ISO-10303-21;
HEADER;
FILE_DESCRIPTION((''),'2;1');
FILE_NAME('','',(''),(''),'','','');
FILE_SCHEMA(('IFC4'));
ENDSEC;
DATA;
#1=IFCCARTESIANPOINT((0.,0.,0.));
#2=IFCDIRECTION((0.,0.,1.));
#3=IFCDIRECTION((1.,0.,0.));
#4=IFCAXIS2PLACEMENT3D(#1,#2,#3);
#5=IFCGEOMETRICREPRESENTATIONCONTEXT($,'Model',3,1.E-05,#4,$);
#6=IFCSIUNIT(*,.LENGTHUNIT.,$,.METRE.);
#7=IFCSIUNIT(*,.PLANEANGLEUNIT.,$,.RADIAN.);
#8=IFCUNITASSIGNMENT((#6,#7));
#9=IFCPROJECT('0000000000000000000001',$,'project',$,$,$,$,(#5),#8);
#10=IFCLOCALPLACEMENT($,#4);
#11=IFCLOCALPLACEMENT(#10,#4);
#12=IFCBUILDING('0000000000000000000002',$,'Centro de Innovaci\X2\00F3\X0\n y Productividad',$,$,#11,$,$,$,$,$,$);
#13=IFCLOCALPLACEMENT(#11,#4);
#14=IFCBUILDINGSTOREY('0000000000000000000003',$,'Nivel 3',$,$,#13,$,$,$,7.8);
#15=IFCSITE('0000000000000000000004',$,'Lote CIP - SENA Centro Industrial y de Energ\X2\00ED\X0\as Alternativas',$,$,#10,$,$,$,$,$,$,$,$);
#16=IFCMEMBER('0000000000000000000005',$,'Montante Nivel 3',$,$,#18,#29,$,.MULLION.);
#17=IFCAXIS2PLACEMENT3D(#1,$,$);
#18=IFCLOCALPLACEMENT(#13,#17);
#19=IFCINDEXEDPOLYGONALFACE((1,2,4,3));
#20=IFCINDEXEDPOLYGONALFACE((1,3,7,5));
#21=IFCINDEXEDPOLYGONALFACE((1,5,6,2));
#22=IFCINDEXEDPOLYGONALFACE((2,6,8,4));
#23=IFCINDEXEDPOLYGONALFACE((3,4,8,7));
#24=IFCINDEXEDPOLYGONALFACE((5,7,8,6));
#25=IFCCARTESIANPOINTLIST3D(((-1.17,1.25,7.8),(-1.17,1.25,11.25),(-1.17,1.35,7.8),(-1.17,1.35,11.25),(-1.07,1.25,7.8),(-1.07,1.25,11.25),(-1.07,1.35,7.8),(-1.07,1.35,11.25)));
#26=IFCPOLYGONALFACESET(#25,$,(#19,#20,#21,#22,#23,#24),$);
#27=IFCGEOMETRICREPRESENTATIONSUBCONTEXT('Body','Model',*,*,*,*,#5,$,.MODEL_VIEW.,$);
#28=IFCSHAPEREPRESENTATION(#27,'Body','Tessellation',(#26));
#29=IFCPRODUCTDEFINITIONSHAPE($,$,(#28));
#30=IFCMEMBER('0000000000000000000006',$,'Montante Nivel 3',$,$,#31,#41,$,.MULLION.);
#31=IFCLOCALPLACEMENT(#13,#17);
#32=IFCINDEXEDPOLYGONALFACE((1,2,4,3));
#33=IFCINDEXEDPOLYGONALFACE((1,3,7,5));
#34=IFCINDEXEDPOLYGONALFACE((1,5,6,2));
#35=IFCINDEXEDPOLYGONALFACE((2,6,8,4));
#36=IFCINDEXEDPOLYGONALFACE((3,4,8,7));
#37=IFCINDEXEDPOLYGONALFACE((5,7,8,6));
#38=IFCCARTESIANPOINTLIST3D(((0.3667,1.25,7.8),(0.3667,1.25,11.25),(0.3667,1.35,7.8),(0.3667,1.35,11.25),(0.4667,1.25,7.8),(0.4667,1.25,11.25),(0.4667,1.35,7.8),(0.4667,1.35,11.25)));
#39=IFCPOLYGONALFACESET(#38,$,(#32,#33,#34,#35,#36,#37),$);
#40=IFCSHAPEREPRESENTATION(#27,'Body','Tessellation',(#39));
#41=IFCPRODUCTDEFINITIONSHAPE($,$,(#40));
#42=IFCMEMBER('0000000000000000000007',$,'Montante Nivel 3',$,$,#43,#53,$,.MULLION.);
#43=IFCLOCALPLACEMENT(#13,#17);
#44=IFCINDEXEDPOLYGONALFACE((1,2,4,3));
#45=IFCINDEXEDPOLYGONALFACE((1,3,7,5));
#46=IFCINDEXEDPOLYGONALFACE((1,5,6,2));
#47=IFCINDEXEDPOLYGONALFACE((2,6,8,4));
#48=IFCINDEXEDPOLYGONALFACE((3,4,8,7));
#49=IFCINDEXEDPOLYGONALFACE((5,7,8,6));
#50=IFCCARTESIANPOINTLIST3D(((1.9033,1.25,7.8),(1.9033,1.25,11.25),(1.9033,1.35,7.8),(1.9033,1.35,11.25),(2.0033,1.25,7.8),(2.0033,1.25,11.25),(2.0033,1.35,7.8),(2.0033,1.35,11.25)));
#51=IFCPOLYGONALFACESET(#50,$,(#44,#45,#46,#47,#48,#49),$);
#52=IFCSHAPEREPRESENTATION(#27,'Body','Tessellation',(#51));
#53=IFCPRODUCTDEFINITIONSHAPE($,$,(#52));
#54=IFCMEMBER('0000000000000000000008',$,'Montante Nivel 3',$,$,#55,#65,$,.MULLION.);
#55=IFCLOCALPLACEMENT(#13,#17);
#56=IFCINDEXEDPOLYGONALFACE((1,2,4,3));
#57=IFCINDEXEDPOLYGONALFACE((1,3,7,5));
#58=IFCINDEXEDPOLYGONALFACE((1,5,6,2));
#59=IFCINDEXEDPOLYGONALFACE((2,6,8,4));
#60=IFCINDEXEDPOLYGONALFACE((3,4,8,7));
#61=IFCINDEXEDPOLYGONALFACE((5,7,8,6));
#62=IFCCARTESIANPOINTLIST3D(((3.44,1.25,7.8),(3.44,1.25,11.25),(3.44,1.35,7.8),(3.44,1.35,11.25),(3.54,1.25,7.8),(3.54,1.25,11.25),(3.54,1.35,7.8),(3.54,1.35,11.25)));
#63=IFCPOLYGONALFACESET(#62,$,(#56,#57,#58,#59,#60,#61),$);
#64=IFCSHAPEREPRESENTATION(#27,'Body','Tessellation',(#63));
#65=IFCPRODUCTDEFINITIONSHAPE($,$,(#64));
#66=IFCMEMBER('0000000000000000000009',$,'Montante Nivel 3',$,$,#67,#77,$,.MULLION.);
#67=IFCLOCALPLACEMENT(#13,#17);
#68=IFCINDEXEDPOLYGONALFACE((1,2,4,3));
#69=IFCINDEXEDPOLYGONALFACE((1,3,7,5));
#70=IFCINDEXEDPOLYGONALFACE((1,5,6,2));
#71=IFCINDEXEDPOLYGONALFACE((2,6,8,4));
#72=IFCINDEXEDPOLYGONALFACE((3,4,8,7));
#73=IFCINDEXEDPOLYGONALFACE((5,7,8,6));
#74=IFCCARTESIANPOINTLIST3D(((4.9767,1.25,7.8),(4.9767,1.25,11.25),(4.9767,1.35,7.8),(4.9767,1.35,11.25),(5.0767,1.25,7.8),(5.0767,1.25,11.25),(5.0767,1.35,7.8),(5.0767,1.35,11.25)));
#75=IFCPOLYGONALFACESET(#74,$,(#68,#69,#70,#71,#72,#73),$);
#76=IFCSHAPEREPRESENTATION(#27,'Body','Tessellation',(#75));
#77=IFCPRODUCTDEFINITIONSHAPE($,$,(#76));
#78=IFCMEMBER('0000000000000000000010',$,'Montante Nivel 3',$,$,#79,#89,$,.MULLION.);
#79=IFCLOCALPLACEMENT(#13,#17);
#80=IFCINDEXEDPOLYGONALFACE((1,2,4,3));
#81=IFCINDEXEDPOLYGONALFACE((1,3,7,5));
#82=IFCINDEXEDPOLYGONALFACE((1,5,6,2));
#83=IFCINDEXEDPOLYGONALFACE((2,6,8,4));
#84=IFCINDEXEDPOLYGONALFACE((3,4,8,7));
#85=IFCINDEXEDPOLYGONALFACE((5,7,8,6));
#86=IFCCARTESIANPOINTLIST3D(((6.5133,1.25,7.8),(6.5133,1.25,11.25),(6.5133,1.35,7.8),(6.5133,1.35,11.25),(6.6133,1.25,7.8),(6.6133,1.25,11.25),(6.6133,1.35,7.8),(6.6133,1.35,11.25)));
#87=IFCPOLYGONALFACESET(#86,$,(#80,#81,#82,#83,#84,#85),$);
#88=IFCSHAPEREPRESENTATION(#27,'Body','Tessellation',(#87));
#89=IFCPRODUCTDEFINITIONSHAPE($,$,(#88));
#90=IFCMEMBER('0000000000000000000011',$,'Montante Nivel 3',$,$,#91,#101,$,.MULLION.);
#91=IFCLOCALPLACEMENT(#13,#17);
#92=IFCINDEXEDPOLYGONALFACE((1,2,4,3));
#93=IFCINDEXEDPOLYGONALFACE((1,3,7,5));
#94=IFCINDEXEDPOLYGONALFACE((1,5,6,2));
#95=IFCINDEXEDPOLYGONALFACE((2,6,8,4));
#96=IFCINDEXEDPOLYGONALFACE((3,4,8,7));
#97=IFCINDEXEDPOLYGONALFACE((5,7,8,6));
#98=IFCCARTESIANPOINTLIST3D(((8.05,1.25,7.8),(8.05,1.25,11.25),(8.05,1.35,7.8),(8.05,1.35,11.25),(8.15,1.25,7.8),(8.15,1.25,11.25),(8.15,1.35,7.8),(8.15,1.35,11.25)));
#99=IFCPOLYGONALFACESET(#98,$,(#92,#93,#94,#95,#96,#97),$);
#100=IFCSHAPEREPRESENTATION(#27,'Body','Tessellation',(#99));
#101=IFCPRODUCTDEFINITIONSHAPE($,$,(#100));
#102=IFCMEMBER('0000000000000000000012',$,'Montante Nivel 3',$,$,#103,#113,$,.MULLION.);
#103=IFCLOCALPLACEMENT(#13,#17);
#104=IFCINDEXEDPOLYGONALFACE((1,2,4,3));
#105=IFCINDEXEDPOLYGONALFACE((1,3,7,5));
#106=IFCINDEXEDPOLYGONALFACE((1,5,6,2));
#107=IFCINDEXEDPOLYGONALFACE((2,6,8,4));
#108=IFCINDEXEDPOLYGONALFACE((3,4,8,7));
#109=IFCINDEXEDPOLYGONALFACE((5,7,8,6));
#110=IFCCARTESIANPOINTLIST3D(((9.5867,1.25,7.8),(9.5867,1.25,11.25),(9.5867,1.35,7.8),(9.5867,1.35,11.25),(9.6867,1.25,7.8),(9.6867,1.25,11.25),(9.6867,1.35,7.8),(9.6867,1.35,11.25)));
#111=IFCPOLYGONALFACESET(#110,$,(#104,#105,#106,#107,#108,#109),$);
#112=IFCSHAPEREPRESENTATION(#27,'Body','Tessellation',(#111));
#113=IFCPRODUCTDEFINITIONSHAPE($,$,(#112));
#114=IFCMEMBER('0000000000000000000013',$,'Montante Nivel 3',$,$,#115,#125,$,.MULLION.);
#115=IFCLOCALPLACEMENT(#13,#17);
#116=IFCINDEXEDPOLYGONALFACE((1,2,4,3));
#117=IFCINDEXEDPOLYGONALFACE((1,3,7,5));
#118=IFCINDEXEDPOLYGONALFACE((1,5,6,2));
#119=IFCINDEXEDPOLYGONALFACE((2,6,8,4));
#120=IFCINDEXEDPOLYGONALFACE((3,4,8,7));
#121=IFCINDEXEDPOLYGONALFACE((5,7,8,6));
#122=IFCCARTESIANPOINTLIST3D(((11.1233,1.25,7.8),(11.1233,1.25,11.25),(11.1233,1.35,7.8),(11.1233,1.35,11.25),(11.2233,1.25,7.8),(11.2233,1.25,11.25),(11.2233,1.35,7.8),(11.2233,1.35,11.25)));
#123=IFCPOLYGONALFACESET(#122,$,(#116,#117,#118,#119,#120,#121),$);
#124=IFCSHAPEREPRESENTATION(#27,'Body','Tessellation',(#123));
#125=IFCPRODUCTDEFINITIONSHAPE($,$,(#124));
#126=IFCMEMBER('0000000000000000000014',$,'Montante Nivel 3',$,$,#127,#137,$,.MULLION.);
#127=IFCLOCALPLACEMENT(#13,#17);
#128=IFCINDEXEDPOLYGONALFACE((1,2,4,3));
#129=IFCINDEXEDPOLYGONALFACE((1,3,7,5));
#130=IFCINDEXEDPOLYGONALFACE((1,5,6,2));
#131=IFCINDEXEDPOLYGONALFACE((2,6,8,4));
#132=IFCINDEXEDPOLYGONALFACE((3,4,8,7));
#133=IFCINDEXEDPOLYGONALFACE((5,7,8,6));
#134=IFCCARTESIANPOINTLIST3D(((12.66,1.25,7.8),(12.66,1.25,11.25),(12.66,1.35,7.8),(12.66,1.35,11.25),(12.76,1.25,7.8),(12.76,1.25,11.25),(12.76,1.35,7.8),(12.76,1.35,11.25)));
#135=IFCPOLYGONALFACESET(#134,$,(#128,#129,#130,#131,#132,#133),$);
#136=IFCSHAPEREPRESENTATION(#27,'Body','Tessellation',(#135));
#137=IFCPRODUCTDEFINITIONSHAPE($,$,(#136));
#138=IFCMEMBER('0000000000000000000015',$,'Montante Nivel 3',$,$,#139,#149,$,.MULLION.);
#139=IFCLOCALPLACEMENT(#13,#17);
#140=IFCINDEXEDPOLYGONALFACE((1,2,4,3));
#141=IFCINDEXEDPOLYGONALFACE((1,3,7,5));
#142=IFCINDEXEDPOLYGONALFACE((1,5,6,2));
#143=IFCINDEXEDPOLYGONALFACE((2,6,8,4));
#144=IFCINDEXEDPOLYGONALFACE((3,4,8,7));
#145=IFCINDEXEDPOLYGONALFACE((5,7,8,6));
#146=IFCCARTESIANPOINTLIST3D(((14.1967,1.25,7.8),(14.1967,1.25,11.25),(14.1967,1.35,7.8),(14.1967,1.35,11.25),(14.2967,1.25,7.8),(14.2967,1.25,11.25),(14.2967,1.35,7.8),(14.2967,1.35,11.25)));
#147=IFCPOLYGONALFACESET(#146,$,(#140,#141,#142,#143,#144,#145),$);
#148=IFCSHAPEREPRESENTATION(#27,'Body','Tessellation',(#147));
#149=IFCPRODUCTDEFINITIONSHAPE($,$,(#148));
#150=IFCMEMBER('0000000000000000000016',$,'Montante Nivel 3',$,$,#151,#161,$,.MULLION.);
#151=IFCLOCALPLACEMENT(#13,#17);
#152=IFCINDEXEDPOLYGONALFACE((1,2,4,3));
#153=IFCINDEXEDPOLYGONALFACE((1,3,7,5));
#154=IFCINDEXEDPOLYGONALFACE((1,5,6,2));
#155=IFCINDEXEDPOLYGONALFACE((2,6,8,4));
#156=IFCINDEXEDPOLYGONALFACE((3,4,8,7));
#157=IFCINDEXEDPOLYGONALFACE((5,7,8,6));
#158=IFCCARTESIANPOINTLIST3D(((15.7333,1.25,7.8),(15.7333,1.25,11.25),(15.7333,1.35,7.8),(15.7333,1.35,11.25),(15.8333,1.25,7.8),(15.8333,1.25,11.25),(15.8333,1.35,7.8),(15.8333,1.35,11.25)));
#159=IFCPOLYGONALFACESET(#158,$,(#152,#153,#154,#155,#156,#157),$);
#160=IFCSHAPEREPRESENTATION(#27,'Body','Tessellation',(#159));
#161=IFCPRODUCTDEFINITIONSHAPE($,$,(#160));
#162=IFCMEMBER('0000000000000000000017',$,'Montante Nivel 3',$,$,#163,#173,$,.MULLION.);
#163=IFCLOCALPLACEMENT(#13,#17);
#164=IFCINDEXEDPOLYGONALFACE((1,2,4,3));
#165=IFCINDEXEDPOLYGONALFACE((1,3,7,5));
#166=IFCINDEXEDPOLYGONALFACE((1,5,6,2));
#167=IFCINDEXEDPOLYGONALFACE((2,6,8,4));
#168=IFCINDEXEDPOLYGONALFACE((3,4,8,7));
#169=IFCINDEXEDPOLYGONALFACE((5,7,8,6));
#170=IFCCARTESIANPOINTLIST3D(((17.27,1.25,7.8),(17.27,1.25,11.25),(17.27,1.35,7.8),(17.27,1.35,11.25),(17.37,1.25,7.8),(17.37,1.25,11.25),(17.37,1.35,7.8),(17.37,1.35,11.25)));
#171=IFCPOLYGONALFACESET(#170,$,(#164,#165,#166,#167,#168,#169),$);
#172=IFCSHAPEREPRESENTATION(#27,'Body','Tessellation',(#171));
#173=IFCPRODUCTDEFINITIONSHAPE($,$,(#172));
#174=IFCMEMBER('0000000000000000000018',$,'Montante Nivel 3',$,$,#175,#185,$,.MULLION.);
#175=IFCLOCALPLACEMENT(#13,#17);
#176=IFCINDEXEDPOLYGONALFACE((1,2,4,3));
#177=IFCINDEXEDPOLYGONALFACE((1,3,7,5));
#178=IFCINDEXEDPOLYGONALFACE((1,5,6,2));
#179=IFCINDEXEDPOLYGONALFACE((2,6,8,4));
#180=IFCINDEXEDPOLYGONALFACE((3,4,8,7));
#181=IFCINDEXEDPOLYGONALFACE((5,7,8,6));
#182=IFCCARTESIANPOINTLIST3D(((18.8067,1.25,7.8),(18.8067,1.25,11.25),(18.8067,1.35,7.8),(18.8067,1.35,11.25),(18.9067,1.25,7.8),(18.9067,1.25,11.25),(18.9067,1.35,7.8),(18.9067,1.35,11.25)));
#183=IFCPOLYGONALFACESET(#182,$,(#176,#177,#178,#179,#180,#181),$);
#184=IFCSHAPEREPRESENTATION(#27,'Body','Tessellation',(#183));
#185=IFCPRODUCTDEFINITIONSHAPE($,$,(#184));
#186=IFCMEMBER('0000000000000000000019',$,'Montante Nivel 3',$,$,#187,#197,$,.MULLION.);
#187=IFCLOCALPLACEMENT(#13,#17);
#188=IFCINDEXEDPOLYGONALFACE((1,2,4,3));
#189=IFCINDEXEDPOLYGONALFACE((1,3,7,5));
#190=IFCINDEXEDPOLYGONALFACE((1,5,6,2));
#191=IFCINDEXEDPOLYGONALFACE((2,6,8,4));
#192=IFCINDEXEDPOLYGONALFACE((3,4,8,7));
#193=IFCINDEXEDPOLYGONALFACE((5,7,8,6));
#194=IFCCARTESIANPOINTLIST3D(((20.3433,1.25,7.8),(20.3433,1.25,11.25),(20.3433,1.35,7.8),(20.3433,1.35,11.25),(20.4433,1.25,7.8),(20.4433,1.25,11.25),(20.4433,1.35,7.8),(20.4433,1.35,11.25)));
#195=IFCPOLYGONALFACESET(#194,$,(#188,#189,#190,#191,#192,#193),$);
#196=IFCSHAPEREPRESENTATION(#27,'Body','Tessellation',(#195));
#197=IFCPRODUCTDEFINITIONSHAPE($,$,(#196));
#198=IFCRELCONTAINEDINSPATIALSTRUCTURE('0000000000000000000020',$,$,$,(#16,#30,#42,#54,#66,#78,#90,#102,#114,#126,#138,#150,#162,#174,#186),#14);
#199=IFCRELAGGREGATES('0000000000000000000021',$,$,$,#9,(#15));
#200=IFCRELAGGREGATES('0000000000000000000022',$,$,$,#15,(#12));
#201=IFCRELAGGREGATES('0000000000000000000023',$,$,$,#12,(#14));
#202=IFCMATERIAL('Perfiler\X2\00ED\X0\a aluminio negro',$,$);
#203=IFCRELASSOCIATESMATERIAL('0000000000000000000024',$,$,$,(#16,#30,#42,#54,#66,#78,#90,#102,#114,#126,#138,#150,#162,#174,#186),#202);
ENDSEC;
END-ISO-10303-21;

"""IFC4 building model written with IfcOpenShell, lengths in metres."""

from ifc_helpers import new_model, si_unit, frame, origin_with_axes, place, context, subcontext, project, spatial, polyline, outline, extrude, material, element, save


model = new_model("IFC4")

# Units and contexts
model_context = context("Model", 3, precision=1e-05, world=origin_with_axes())
body_context = subcontext(model_context, "Body", "Model", "MODEL_VIEW")
ifc_project = project(units=[si_unit("LENGTHUNIT", "METRE"), si_unit("PLANEANGLEUNIT", "RADIAN")], contexts=[model_context])

# Site, building, storey
site_placement = place(None, origin_with_axes())
site = spatial("IfcSite", under=ifc_project, at=site_placement, Name="Lote CIP - SENA Centro Industrial y de Energías Alternativas")
building_placement = place(site_placement, origin_with_axes())
building = spatial("IfcBuilding", under=site, at=building_placement, Name="Centro de Innovación y Productividad")
storey_placement = place(building_placement, origin_with_axes())
storey = spatial("IfcBuildingStorey", under=building, at=storey_placement, Name="Nivel 3", Elevation=7.8)

# Members
ifc_material_1 = material(Name="Perfilería aluminio negro")
member_1_placement = place(storey_placement, origin_with_axes())
element("IfcMember", 1, at=member_1_placement, inside=storey, material=ifc_material_1, Name="Montante Nivel 3", PredefinedType="MULLION", context=body_context, shape_type="SweptSolid", body=[
    extrude(outline(polyline([(-1.07, 1.35), (-1.07, 1.25), (-1.17, 1.25), (-1.17, 1.35), (-1.07, 1.35)])), frame((0.0, 0.0, 7.8)), (0.0, 0.0, 1.0), 3.45),
])
member_2_placement = place(storey_placement, origin_with_axes())
element("IfcMember", 2, at=member_2_placement, inside=storey, material=ifc_material_1, Name="Montante Nivel 3", PredefinedType="MULLION", context=body_context, shape_type="SweptSolid", body=[
    extrude(outline(polyline([(0.4667, 1.35), (0.4667, 1.25), (0.3667, 1.25), (0.3667, 1.35), (0.4667, 1.35)])), frame((0.0, 0.0, 7.8)), (0.0, 0.0, 1.0), 3.45),
])
member_3_placement = place(storey_placement, origin_with_axes())
element("IfcMember", 3, at=member_3_placement, inside=storey, material=ifc_material_1, Name="Montante Nivel 3", PredefinedType="MULLION", context=body_context, shape_type="SweptSolid", body=[
    extrude(outline(polyline([(2.0033, 1.35), (2.0033, 1.25), (1.9033, 1.25), (1.9033, 1.35), (2.0033, 1.35)])), frame((0.0, 0.0, 7.8)), (0.0, 0.0, 1.0), 3.45),
])
member_4_placement = place(storey_placement, origin_with_axes())
element("IfcMember", 4, at=member_4_placement, inside=storey, material=ifc_material_1, Name="Montante Nivel 3", PredefinedType="MULLION", context=body_context, shape_type="SweptSolid", body=[
    extrude(outline(polyline([(3.54, 1.35), (3.54, 1.25), (3.44, 1.25), (3.44, 1.35), (3.54, 1.35)])), frame((0.0, 0.0, 7.8)), (0.0, 0.0, 1.0), 3.45),
])
member_5_placement = place(storey_placement, origin_with_axes())
element("IfcMember", 5, at=member_5_placement, inside=storey, material=ifc_material_1, Name="Montante Nivel 3", PredefinedType="MULLION", context=body_context, shape_type="SweptSolid", body=[
    extrude(outline(polyline([(5.0767, 1.35), (5.0767, 1.25), (4.9767, 1.25), (4.9767, 1.35), (5.0767, 1.35)])), frame((0.0, 0.0, 7.8)), (0.0, 0.0, 1.0), 3.45),
])
member_6_placement = place(storey_placement, origin_with_axes())
element("IfcMember", 6, at=member_6_placement, inside=storey, material=ifc_material_1, Name="Montante Nivel 3", PredefinedType="MULLION", context=body_context, shape_type="SweptSolid", body=[
    extrude(outline(polyline([(6.6133, 1.35), (6.6133, 1.25), (6.5133, 1.25), (6.5133, 1.35), (6.6133, 1.35)])), frame((0.0, 0.0, 7.8)), (0.0, 0.0, 1.0), 3.45),
])
member_7_placement = place(storey_placement, origin_with_axes())
element("IfcMember", 7, at=member_7_placement, inside=storey, material=ifc_material_1, Name="Montante Nivel 3", PredefinedType="MULLION", context=body_context, shape_type="SweptSolid", body=[
    extrude(outline(polyline([(8.15, 1.35), (8.15, 1.25), (8.05, 1.25), (8.05, 1.35), (8.15, 1.35)])), frame((0.0, 0.0, 7.8)), (0.0, 0.0, 1.0), 3.45),
])
member_8_placement = place(storey_placement, origin_with_axes())
element("IfcMember", 8, at=member_8_placement, inside=storey, material=ifc_material_1, Name="Montante Nivel 3", PredefinedType="MULLION", context=body_context, shape_type="SweptSolid", body=[
    extrude(outline(polyline([(9.6867, 1.35), (9.6867, 1.25), (9.5867, 1.25), (9.5867, 1.35), (9.6867, 1.35)])), frame((0.0, 0.0, 7.8)), (0.0, 0.0, 1.0), 3.45),
])
member_9_placement = place(storey_placement, origin_with_axes())
element("IfcMember", 9, at=member_9_placement, inside=storey, material=ifc_material_1, Name="Montante Nivel 3", PredefinedType="MULLION", context=body_context, shape_type="SweptSolid", body=[
    extrude(outline(polyline([(11.2233, 1.35), (11.2233, 1.25), (11.1233, 1.25), (11.1233, 1.35), (11.2233, 1.35)])), frame((0.0, 0.0, 7.8)), (0.0, 0.0, 1.0), 3.45),
])
member_10_placement = place(storey_placement, origin_with_axes())
element("IfcMember", 10, at=member_10_placement, inside=storey, material=ifc_material_1, Name="Montante Nivel 3", PredefinedType="MULLION", context=body_context, shape_type="SweptSolid", body=[
    extrude(outline(polyline([(12.76, 1.35), (12.76, 1.25), (12.66, 1.25), (12.66, 1.35), (12.76, 1.35)])), frame((0.0, 0.0, 7.8)), (0.0, 0.0, 1.0), 3.45),
])
member_11_placement = place(storey_placement, origin_with_axes())
element("IfcMember", 11, at=member_11_placement, inside=storey, material=ifc_material_1, Name="Montante Nivel 3", PredefinedType="MULLION", context=body_context, shape_type="SweptSolid", body=[
    extrude(outline(polyline([(14.2967, 1.35), (14.2967, 1.25), (14.1967, 1.25), (14.1967, 1.35), (14.2967, 1.35)])), frame((0.0, 0.0, 7.8)), (0.0, 0.0, 1.0), 3.45),
])
member_12_placement = place(storey_placement, origin_with_axes())
element("IfcMember", 12, at=member_12_placement, inside=storey, material=ifc_material_1, Name="Montante Nivel 3", PredefinedType="MULLION", context=body_context, shape_type="SweptSolid", body=[
    extrude(outline(polyline([(15.8333, 1.35), (15.8333, 1.25), (15.7333, 1.25), (15.7333, 1.35), (15.8333, 1.35)])), frame((0.0, 0.0, 7.8)), (0.0, 0.0, 1.0), 3.45),
])
member_13_placement = place(storey_placement, origin_with_axes())
element("IfcMember", 13, at=member_13_placement, inside=storey, material=ifc_material_1, Name="Montante Nivel 3", PredefinedType="MULLION", context=body_context, shape_type="SweptSolid", body=[
    extrude(outline(polyline([(17.37, 1.35), (17.37, 1.25), (17.27, 1.25), (17.27, 1.35), (17.37, 1.35)])), frame((0.0, 0.0, 7.8)), (0.0, 0.0, 1.0), 3.45),
])
member_14_placement = place(storey_placement, origin_with_axes())
element("IfcMember", 14, at=member_14_placement, inside=storey, material=ifc_material_1, Name="Montante Nivel 3", PredefinedType="MULLION", context=body_context, shape_type="SweptSolid", body=[
    extrude(outline(polyline([(18.9067, 1.35), (18.9067, 1.25), (18.8067, 1.25), (18.8067, 1.35), (18.9067, 1.35)])), frame((0.0, 0.0, 7.8)), (0.0, 0.0, 1.0), 3.45),
])
member_15_placement = place(storey_placement, origin_with_axes())
element("IfcMember", 15, at=member_15_placement, inside=storey, material=ifc_material_1, Name="Montante Nivel 3", PredefinedType="MULLION", context=body_context, shape_type="SweptSolid", body=[
    extrude(outline(polyline([(20.4433, 1.35), (20.4433, 1.25), (20.3433, 1.25), (20.3433, 1.35), (20.4433, 1.35)])), frame((0.0, 0.0, 7.8)), (0.0, 0.0, 1.0), 3.45),
])

save(model, "model.ifc")
